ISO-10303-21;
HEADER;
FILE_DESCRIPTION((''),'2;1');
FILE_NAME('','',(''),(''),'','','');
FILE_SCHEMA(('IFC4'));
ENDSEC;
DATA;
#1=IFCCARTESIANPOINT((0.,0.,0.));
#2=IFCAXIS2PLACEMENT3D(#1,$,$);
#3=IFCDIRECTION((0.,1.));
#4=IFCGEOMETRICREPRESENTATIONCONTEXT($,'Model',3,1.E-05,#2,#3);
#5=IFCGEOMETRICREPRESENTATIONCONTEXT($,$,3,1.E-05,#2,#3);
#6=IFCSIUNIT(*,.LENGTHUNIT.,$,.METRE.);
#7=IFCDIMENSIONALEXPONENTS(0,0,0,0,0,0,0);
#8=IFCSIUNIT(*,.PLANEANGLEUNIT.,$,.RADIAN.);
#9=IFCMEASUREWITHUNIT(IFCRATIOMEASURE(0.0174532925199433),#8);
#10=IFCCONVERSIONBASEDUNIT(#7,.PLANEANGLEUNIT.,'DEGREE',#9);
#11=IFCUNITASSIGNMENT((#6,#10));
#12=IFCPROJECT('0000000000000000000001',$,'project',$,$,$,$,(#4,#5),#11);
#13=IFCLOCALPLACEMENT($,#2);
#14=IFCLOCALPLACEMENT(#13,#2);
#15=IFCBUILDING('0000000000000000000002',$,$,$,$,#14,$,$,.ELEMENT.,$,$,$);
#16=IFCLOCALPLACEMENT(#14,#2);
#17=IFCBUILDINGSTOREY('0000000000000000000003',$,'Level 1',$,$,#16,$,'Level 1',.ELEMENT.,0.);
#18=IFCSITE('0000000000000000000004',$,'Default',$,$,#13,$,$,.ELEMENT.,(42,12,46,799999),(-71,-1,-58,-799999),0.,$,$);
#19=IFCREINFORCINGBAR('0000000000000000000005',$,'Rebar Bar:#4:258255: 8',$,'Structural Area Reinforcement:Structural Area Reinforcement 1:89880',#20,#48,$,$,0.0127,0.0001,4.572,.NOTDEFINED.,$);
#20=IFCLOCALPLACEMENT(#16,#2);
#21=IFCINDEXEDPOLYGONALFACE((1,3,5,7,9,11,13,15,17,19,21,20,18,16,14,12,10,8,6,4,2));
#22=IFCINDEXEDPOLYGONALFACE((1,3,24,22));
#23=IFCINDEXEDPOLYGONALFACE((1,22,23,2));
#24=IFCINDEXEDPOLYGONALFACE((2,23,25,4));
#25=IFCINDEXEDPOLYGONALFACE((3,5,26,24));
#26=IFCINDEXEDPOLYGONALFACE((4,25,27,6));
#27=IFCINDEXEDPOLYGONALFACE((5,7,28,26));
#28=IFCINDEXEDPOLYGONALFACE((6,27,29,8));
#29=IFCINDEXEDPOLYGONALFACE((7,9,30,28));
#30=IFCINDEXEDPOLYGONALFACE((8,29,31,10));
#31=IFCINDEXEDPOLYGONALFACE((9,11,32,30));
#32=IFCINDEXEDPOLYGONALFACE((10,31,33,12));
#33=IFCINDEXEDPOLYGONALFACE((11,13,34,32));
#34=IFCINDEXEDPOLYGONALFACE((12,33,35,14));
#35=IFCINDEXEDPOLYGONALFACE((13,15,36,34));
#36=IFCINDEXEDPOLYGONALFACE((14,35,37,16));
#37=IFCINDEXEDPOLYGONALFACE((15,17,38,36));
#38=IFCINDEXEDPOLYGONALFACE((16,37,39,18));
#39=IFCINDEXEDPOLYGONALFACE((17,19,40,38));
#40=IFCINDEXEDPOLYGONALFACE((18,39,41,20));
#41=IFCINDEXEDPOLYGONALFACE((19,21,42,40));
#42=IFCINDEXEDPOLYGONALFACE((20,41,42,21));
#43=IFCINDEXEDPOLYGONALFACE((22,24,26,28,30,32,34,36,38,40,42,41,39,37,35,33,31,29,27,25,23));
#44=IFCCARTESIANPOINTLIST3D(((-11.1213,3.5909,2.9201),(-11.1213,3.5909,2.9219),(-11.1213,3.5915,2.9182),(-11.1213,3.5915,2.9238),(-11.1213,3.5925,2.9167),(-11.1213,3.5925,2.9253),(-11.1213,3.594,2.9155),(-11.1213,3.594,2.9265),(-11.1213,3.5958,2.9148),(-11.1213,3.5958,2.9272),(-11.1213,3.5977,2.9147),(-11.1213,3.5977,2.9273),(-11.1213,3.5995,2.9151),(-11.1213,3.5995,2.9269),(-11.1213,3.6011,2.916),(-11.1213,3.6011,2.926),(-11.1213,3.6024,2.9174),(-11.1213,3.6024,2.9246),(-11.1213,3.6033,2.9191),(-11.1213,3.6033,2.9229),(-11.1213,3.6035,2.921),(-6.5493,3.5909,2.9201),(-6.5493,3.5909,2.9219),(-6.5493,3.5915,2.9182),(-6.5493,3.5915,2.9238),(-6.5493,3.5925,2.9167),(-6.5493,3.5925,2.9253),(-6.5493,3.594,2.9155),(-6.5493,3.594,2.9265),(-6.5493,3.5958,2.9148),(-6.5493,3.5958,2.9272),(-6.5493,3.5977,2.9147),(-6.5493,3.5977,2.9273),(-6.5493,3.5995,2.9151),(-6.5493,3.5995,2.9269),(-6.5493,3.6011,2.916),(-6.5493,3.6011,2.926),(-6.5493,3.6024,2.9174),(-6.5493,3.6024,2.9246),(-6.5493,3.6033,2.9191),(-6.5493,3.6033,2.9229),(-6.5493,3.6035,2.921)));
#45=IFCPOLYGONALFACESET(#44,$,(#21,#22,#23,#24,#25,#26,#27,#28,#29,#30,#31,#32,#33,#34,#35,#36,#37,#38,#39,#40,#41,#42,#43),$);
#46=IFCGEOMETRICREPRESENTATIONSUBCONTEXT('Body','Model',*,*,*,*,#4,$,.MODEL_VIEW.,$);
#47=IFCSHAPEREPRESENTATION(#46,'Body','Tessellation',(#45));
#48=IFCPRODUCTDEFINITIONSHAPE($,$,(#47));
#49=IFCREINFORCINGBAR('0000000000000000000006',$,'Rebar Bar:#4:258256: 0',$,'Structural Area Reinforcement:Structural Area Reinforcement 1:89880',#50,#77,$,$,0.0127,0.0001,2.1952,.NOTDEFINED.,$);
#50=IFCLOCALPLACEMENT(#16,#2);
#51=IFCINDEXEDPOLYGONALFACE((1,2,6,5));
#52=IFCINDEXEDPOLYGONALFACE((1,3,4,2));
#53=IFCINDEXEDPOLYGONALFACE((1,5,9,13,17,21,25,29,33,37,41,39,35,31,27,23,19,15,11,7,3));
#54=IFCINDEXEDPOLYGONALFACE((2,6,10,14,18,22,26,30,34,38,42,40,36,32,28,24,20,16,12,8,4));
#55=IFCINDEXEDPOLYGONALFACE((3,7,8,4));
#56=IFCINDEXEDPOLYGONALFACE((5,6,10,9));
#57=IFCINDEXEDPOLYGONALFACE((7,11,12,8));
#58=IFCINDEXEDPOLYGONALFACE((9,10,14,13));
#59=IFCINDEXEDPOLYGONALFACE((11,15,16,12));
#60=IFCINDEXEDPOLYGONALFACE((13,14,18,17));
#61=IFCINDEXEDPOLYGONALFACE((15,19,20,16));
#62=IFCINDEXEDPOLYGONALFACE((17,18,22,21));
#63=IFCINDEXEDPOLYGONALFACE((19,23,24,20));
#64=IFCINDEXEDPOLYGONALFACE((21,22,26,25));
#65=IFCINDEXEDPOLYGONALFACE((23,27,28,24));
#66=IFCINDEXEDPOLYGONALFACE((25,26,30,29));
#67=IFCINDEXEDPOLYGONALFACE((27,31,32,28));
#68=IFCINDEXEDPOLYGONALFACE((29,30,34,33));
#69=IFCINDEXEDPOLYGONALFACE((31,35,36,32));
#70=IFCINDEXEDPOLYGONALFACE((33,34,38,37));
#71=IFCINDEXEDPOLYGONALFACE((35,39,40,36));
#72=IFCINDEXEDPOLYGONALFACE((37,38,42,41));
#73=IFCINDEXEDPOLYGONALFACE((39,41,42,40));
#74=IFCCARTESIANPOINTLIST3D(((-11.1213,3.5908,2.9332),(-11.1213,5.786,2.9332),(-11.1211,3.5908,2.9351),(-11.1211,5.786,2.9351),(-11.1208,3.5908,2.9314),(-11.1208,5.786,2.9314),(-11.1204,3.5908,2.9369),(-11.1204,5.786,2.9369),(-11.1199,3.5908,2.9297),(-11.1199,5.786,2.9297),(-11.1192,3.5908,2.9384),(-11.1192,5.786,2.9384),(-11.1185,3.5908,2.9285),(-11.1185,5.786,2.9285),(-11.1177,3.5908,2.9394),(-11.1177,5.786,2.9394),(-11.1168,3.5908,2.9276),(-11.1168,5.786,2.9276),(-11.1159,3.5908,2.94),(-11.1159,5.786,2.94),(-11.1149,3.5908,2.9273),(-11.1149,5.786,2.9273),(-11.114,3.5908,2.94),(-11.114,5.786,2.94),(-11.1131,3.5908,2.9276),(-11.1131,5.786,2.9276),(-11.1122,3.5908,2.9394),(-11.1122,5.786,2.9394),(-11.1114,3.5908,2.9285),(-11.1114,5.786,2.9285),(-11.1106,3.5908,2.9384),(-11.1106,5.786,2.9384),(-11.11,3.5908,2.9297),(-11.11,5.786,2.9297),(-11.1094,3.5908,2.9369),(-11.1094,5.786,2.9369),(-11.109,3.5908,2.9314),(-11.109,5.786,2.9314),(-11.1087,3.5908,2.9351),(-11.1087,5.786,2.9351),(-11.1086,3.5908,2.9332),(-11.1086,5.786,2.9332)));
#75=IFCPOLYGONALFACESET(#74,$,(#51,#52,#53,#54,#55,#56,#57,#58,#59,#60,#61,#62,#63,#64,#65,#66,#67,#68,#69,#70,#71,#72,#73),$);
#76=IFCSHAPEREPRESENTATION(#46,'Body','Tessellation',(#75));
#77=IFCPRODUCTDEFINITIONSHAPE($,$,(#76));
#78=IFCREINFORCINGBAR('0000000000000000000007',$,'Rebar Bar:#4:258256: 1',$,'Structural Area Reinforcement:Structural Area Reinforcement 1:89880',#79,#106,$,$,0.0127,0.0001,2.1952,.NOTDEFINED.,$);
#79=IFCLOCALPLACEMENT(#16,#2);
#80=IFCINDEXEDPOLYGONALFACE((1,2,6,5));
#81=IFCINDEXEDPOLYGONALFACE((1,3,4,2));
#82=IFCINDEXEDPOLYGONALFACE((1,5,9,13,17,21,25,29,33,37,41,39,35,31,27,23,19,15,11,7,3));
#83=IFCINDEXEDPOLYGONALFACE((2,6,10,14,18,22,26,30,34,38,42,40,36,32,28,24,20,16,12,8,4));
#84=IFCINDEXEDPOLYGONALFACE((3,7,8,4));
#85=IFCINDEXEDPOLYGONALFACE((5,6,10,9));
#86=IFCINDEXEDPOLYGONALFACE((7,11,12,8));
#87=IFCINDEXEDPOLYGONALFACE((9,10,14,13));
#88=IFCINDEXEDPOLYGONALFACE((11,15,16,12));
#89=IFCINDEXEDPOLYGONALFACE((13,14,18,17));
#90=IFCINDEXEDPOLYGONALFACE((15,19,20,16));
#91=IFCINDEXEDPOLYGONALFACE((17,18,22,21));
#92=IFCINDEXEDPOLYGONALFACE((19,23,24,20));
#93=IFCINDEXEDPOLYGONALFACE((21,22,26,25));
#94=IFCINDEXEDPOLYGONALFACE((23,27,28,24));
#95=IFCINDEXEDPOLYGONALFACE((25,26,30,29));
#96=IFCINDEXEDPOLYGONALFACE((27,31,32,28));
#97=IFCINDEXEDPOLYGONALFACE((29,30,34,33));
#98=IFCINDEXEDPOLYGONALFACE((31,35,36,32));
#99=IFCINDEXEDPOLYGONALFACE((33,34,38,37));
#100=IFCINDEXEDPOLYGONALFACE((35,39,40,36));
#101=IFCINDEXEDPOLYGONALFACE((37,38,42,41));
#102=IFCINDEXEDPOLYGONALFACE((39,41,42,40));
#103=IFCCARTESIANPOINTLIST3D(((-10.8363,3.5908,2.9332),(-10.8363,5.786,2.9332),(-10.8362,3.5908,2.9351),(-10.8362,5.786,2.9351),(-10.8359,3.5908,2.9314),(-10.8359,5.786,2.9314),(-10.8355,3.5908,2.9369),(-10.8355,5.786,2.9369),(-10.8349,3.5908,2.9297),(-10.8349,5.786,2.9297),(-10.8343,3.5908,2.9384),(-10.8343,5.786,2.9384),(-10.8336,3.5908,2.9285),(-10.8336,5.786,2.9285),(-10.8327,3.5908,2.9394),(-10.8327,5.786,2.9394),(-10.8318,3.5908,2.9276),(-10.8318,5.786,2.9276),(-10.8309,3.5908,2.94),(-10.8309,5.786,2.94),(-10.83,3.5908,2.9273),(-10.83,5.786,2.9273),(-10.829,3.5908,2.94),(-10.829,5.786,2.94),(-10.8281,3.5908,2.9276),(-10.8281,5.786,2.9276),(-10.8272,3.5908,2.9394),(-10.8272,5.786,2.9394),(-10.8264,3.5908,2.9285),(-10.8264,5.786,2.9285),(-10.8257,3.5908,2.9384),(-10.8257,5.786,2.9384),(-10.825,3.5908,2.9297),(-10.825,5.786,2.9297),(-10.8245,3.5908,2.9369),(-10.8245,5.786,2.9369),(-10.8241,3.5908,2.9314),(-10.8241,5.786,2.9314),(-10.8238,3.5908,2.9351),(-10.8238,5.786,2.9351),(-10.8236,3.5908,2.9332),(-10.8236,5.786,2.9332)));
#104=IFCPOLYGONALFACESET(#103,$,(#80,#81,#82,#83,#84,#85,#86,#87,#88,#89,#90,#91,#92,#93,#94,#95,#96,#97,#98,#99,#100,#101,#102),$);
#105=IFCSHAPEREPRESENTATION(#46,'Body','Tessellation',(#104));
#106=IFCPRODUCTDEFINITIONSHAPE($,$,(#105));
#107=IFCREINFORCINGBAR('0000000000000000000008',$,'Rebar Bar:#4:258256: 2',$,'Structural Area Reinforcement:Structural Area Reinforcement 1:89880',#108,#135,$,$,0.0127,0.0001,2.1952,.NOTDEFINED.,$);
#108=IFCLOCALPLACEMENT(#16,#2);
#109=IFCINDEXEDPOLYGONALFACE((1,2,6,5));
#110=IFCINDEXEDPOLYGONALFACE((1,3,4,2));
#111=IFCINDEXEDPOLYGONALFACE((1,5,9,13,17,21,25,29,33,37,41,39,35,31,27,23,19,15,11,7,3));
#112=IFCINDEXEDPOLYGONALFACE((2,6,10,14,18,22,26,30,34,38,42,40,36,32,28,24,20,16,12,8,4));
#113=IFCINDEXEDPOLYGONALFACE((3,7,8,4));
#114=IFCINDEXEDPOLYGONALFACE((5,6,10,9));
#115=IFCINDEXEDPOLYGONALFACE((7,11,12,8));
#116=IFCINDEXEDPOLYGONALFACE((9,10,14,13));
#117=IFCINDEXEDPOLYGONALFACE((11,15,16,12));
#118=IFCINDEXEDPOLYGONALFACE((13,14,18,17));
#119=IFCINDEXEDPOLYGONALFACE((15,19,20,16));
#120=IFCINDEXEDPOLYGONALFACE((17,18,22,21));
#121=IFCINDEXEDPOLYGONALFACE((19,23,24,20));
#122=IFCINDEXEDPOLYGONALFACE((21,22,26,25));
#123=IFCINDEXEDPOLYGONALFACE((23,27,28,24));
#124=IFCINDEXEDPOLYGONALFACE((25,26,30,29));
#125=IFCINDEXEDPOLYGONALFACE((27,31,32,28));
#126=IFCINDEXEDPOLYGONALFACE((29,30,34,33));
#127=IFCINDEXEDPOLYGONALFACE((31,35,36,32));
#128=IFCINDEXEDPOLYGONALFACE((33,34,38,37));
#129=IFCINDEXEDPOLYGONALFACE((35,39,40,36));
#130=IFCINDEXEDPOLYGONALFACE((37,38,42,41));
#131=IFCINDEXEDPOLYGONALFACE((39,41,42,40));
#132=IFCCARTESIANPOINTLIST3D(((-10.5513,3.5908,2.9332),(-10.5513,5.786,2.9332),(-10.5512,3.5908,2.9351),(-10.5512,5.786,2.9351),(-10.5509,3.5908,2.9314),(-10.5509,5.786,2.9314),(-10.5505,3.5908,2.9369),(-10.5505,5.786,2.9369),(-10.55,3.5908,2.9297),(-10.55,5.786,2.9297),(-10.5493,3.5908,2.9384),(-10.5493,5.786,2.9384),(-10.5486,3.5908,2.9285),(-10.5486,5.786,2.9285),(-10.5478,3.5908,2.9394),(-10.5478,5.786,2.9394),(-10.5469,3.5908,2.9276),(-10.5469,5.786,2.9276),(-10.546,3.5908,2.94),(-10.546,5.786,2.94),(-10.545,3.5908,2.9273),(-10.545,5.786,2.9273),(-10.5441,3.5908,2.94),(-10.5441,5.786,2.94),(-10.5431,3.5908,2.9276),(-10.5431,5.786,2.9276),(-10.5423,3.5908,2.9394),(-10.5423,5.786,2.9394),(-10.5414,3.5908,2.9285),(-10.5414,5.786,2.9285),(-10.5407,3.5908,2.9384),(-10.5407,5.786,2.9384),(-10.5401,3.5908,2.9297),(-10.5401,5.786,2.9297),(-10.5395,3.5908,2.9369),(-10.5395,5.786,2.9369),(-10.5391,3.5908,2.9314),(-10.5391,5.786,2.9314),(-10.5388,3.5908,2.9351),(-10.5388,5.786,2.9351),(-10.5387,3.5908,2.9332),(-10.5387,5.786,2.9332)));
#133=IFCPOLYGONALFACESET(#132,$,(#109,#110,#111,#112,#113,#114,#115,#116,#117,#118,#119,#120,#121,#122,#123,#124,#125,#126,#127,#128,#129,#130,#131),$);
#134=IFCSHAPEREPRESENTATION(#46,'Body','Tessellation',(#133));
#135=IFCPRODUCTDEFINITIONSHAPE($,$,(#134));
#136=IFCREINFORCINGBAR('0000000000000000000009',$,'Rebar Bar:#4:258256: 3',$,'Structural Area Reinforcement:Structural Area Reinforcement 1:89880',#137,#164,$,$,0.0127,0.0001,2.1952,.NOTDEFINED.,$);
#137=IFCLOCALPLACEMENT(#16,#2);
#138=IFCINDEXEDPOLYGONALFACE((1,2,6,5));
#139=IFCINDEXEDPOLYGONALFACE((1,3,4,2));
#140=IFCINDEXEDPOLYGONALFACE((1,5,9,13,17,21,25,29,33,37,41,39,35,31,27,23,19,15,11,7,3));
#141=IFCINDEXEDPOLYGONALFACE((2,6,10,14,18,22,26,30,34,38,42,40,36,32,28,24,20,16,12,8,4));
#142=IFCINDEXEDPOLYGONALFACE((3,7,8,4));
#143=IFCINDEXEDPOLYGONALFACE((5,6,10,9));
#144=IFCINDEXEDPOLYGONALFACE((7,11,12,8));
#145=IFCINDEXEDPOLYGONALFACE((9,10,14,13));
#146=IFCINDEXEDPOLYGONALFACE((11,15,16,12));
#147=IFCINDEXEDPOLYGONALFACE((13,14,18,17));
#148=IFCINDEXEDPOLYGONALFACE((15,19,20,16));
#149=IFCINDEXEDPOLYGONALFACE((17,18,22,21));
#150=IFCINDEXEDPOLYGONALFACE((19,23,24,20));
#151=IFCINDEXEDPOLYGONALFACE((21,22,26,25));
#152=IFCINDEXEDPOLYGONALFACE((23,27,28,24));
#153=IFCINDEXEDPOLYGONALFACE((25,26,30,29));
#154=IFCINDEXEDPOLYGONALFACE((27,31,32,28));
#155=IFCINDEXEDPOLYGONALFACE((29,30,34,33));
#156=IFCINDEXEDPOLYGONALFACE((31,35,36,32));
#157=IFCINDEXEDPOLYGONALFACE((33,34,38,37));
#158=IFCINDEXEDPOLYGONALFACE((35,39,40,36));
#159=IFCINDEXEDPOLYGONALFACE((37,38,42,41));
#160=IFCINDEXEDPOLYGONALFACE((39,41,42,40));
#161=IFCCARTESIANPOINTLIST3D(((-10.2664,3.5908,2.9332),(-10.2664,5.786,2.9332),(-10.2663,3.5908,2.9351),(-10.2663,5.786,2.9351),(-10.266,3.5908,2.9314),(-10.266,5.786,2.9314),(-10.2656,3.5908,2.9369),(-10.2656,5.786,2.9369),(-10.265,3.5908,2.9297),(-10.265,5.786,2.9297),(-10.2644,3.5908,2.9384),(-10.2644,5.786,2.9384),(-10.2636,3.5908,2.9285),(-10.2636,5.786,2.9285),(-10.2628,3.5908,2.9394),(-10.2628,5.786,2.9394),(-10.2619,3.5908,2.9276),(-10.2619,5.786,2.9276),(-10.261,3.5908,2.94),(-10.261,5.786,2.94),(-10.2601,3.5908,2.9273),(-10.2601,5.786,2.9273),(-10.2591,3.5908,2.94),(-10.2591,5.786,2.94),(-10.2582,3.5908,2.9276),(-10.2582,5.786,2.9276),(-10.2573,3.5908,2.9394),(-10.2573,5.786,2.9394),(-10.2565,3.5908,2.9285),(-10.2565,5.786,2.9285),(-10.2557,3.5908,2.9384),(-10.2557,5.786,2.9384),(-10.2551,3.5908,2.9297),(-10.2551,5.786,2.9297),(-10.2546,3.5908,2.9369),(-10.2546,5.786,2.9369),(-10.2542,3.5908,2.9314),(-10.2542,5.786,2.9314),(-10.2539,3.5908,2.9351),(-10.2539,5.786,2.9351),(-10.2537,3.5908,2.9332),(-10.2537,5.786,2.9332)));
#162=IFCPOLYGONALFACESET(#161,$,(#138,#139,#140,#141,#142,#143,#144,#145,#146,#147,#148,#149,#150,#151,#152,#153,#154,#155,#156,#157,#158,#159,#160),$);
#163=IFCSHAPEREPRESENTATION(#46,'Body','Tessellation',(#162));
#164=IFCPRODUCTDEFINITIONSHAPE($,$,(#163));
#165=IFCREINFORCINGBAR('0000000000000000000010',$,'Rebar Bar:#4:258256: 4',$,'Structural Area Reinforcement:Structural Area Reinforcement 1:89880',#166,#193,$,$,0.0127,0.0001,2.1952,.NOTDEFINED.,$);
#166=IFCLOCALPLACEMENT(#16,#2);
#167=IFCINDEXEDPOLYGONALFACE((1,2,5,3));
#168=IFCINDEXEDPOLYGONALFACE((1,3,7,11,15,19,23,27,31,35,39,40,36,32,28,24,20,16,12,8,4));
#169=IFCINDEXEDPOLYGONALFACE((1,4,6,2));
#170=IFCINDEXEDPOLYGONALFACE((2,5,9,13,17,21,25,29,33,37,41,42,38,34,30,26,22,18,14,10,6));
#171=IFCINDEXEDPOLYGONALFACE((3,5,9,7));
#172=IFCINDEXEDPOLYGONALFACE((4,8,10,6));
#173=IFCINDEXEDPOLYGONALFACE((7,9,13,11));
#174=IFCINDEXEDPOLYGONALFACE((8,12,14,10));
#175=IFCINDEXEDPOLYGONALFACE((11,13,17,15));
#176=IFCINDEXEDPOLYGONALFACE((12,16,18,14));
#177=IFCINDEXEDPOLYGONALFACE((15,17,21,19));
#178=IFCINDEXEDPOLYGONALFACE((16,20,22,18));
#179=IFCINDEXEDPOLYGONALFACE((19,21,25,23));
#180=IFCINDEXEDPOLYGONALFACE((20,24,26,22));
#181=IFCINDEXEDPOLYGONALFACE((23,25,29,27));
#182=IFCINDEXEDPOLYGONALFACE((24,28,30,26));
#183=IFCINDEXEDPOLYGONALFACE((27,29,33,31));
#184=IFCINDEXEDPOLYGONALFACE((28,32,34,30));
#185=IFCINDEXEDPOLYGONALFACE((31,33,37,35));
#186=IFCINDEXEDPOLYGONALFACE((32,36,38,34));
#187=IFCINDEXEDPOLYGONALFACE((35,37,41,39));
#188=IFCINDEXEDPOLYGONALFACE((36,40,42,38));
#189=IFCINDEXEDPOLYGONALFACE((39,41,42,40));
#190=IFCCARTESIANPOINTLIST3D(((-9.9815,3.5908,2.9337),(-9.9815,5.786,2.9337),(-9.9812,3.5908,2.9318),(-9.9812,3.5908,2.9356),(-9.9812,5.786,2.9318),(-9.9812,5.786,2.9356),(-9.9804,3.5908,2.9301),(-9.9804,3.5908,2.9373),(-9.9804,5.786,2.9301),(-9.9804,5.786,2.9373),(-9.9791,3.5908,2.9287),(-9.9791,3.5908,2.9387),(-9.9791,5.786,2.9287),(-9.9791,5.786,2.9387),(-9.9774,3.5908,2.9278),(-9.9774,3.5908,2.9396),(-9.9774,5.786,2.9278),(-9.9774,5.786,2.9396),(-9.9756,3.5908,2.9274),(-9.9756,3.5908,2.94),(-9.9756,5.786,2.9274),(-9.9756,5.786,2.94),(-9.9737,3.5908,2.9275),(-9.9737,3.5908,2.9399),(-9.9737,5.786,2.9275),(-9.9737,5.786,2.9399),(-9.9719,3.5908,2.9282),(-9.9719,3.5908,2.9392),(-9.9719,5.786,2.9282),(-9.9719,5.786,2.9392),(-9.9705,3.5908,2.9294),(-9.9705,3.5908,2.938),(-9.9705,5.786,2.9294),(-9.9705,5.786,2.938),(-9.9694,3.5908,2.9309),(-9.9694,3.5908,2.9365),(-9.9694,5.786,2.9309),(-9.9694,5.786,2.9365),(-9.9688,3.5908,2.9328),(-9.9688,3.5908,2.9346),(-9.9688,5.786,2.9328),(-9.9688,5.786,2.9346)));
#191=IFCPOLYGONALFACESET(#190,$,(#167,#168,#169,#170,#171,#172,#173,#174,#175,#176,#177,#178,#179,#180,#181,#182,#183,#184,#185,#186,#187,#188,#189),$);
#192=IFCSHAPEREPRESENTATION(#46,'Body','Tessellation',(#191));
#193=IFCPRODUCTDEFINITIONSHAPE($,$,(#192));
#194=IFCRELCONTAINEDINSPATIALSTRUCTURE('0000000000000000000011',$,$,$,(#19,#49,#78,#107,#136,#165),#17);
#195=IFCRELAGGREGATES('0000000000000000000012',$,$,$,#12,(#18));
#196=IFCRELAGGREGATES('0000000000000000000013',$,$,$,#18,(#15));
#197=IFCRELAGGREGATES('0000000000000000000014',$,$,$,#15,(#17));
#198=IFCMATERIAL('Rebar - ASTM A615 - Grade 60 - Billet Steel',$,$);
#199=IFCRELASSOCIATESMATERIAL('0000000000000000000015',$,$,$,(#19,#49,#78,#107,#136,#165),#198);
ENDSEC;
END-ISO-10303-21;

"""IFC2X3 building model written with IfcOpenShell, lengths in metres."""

from ifc_helpers import new_model, entity, si_unit, converted_unit, direction, origin, place, context, subcontext, project, spatial, material, element, save


model = new_model("IFC2X3")

# Units and contexts
model_context = context("Model", 3, precision=1e-05, world=origin(), true_north=direction((0.0, 1.0)))
context_of_model = context(None, 3, precision=1e-05, world=origin(), true_north=direction((0.0, 1.0)))
body_context = subcontext(model_context, "Body", "Model", "MODEL_VIEW")
ifc_project = project(units=[si_unit("LENGTHUNIT", "METRE"), converted_unit("PLANEANGLEUNIT", "DEGREE", entity("IfcRatioMeasure", 0.0174532925199433), si_unit("PLANEANGLEUNIT", "RADIAN"), dimensions=[0, 0, 0, 0, 0, 0, 0])], contexts=[model_context, context_of_model])

# Site, building, storey
site_placement = place(None, origin())
site = spatial("IfcSite", under=ifc_project, at=site_placement, Name="Default", CompositionType="ELEMENT", RefLatitude=(42, 12, 46, 799999), RefLongitude=(-71, -1, -58, -799999), RefElevation=0.0)
building_placement = place(site_placement, origin())
building = spatial("IfcBuilding", under=site, at=building_placement, CompositionType="ELEMENT")
storey_placement = place(building_placement, origin())
storey = spatial("IfcBuildingStorey", under=building, at=storey_placement, Name="Level 1", LongName="Level 1", CompositionType="ELEMENT", Elevation=0.0)

# Reinforcing bars
ifc_material_1 = material(Name="Rebar - ASTM A615 - Grade 60 - Billet Steel")
reinforcing_bar_1_placement = place(storey_placement, origin())
element("IfcReinforcingBar", 1, at=reinforcing_bar_1_placement, inside=storey, material=ifc_material_1, Name="Rebar Bar:#4:258255: 8", ObjectType="Structural Area Reinforcement:Structural Area Reinforcement 1:89880", BarLength=4.572, BarRole="NOTDEFINED", CrossSectionArea=0.0001, NominalDiameter=0.0127, context=body_context, shape_type="AdvancedSweptSolid", body=[
    entity("IfcSweptDiskSolid", entity("IfcCompositeCurve", [entity("IfcCompositeCurveSegment", "CONTINUOUS", True, entity("IfcPolyline", [entity("IfcCartesianPoint", [-11.1213, 3.5972, 2.921]), entity("IfcCartesianPoint", [-6.5493, 3.5972, 2.921])]))], False), 0.0063, None, 0.0, 1.0),
])
reinforcing_bar_2_placement = place(storey_placement, origin())
element("IfcReinforcingBar", 2, at=reinforcing_bar_2_placement, inside=storey, material=ifc_material_1, Name="Rebar Bar:#4:258256: 0", ObjectType="Structural Area Reinforcement:Structural Area Reinforcement 1:89880", BarLength=2.1952, BarRole="NOTDEFINED", CrossSectionArea=0.0001, NominalDiameter=0.0127, context=body_context, shape_type="AdvancedSweptSolid", body=[
    entity("IfcSweptDiskSolid", entity("IfcCompositeCurve", [entity("IfcCompositeCurveSegment", "CONTINUOUS", True, entity("IfcPolyline", [entity("IfcCartesianPoint", [-11.1149, 5.786, 2.9337]), entity("IfcCartesianPoint", [-11.1149, 3.5908, 2.9337])]))], False), 0.0063, None, 0.0, 1.0),
])
reinforcing_bar_3_placement = place(storey_placement, origin())
element("IfcReinforcingBar", 3, at=reinforcing_bar_3_placement, inside=storey, material=ifc_material_1, Name="Rebar Bar:#4:258256: 1", ObjectType="Structural Area Reinforcement:Structural Area Reinforcement 1:89880", BarLength=2.1952, BarRole="NOTDEFINED", CrossSectionArea=0.0001, NominalDiameter=0.0127, context=body_context, shape_type="AdvancedSweptSolid", body=[
    entity("IfcSweptDiskSolid", entity("IfcCompositeCurve", [entity("IfcCompositeCurveSegment", "CONTINUOUS", True, entity("IfcPolyline", [entity("IfcCartesianPoint", [-10.83, 5.786, 2.9337]), entity("IfcCartesianPoint", [-10.83, 3.5908, 2.9337])]))], False), 0.0063, None, 0.0, 1.0),
])
reinforcing_bar_4_placement = place(storey_placement, origin())
element("IfcReinforcingBar", 4, at=reinforcing_bar_4_placement, inside=storey, material=ifc_material_1, Name="Rebar Bar:#4:258256: 2", ObjectType="Structural Area Reinforcement:Structural Area Reinforcement 1:89880", BarLength=2.1952, BarRole="NOTDEFINED", CrossSectionArea=0.0001, NominalDiameter=0.0127, context=body_context, shape_type="AdvancedSweptSolid", body=[
    entity("IfcSweptDiskSolid", entity("IfcCompositeCurve", [entity("IfcCompositeCurveSegment", "CONTINUOUS", True, entity("IfcPolyline", [entity("IfcCartesianPoint", [-10.545, 5.786, 2.9337]), entity("IfcCartesianPoint", [-10.545, 3.5908, 2.9337])]))], False), 0.0063, None, 0.0, 1.0),
])
reinforcing_bar_5_placement = place(storey_placement, origin())
element("IfcReinforcingBar", 5, at=reinforcing_bar_5_placement, inside=storey, material=ifc_material_1, Name="Rebar Bar:#4:258256: 3", ObjectType="Structural Area Reinforcement:Structural Area Reinforcement 1:89880", BarLength=2.1952, BarRole="NOTDEFINED", CrossSectionArea=0.0001, NominalDiameter=0.0127, context=body_context, shape_type="AdvancedSweptSolid", body=[
    entity("IfcSweptDiskSolid", entity("IfcCompositeCurve", [entity("IfcCompositeCurveSegment", "CONTINUOUS", True, entity("IfcPolyline", [entity("IfcCartesianPoint", [-10.2601, 5.786, 2.9337]), entity("IfcCartesianPoint", [-10.2601, 3.5908, 2.9337])]))], False), 0.0063, None, 0.0, 1.0),
])
reinforcing_bar_6_placement = place(storey_placement, origin())
element("IfcReinforcingBar", 6, at=reinforcing_bar_6_placement, inside=storey, material=ifc_material_1, Name="Rebar Bar:#4:258256: 4", ObjectType="Structural Area Reinforcement:Structural Area Reinforcement 1:89880", BarLength=2.1952, BarRole="NOTDEFINED", CrossSectionArea=0.0001, NominalDiameter=0.0127, context=body_context, shape_type="AdvancedSweptSolid", body=[
    entity("IfcSweptDiskSolid", entity("IfcCompositeCurve", [entity("IfcCompositeCurveSegment", "CONTINUOUS", True, entity("IfcPolyline", [entity("IfcCartesianPoint", [-9.9751, 5.786, 2.9337]), entity("IfcCartesianPoint", [-9.9751, 3.5908, 2.9337])]))], False), 0.0063, None, 0.0, 1.0),
])

save(model, "model.ifc")
